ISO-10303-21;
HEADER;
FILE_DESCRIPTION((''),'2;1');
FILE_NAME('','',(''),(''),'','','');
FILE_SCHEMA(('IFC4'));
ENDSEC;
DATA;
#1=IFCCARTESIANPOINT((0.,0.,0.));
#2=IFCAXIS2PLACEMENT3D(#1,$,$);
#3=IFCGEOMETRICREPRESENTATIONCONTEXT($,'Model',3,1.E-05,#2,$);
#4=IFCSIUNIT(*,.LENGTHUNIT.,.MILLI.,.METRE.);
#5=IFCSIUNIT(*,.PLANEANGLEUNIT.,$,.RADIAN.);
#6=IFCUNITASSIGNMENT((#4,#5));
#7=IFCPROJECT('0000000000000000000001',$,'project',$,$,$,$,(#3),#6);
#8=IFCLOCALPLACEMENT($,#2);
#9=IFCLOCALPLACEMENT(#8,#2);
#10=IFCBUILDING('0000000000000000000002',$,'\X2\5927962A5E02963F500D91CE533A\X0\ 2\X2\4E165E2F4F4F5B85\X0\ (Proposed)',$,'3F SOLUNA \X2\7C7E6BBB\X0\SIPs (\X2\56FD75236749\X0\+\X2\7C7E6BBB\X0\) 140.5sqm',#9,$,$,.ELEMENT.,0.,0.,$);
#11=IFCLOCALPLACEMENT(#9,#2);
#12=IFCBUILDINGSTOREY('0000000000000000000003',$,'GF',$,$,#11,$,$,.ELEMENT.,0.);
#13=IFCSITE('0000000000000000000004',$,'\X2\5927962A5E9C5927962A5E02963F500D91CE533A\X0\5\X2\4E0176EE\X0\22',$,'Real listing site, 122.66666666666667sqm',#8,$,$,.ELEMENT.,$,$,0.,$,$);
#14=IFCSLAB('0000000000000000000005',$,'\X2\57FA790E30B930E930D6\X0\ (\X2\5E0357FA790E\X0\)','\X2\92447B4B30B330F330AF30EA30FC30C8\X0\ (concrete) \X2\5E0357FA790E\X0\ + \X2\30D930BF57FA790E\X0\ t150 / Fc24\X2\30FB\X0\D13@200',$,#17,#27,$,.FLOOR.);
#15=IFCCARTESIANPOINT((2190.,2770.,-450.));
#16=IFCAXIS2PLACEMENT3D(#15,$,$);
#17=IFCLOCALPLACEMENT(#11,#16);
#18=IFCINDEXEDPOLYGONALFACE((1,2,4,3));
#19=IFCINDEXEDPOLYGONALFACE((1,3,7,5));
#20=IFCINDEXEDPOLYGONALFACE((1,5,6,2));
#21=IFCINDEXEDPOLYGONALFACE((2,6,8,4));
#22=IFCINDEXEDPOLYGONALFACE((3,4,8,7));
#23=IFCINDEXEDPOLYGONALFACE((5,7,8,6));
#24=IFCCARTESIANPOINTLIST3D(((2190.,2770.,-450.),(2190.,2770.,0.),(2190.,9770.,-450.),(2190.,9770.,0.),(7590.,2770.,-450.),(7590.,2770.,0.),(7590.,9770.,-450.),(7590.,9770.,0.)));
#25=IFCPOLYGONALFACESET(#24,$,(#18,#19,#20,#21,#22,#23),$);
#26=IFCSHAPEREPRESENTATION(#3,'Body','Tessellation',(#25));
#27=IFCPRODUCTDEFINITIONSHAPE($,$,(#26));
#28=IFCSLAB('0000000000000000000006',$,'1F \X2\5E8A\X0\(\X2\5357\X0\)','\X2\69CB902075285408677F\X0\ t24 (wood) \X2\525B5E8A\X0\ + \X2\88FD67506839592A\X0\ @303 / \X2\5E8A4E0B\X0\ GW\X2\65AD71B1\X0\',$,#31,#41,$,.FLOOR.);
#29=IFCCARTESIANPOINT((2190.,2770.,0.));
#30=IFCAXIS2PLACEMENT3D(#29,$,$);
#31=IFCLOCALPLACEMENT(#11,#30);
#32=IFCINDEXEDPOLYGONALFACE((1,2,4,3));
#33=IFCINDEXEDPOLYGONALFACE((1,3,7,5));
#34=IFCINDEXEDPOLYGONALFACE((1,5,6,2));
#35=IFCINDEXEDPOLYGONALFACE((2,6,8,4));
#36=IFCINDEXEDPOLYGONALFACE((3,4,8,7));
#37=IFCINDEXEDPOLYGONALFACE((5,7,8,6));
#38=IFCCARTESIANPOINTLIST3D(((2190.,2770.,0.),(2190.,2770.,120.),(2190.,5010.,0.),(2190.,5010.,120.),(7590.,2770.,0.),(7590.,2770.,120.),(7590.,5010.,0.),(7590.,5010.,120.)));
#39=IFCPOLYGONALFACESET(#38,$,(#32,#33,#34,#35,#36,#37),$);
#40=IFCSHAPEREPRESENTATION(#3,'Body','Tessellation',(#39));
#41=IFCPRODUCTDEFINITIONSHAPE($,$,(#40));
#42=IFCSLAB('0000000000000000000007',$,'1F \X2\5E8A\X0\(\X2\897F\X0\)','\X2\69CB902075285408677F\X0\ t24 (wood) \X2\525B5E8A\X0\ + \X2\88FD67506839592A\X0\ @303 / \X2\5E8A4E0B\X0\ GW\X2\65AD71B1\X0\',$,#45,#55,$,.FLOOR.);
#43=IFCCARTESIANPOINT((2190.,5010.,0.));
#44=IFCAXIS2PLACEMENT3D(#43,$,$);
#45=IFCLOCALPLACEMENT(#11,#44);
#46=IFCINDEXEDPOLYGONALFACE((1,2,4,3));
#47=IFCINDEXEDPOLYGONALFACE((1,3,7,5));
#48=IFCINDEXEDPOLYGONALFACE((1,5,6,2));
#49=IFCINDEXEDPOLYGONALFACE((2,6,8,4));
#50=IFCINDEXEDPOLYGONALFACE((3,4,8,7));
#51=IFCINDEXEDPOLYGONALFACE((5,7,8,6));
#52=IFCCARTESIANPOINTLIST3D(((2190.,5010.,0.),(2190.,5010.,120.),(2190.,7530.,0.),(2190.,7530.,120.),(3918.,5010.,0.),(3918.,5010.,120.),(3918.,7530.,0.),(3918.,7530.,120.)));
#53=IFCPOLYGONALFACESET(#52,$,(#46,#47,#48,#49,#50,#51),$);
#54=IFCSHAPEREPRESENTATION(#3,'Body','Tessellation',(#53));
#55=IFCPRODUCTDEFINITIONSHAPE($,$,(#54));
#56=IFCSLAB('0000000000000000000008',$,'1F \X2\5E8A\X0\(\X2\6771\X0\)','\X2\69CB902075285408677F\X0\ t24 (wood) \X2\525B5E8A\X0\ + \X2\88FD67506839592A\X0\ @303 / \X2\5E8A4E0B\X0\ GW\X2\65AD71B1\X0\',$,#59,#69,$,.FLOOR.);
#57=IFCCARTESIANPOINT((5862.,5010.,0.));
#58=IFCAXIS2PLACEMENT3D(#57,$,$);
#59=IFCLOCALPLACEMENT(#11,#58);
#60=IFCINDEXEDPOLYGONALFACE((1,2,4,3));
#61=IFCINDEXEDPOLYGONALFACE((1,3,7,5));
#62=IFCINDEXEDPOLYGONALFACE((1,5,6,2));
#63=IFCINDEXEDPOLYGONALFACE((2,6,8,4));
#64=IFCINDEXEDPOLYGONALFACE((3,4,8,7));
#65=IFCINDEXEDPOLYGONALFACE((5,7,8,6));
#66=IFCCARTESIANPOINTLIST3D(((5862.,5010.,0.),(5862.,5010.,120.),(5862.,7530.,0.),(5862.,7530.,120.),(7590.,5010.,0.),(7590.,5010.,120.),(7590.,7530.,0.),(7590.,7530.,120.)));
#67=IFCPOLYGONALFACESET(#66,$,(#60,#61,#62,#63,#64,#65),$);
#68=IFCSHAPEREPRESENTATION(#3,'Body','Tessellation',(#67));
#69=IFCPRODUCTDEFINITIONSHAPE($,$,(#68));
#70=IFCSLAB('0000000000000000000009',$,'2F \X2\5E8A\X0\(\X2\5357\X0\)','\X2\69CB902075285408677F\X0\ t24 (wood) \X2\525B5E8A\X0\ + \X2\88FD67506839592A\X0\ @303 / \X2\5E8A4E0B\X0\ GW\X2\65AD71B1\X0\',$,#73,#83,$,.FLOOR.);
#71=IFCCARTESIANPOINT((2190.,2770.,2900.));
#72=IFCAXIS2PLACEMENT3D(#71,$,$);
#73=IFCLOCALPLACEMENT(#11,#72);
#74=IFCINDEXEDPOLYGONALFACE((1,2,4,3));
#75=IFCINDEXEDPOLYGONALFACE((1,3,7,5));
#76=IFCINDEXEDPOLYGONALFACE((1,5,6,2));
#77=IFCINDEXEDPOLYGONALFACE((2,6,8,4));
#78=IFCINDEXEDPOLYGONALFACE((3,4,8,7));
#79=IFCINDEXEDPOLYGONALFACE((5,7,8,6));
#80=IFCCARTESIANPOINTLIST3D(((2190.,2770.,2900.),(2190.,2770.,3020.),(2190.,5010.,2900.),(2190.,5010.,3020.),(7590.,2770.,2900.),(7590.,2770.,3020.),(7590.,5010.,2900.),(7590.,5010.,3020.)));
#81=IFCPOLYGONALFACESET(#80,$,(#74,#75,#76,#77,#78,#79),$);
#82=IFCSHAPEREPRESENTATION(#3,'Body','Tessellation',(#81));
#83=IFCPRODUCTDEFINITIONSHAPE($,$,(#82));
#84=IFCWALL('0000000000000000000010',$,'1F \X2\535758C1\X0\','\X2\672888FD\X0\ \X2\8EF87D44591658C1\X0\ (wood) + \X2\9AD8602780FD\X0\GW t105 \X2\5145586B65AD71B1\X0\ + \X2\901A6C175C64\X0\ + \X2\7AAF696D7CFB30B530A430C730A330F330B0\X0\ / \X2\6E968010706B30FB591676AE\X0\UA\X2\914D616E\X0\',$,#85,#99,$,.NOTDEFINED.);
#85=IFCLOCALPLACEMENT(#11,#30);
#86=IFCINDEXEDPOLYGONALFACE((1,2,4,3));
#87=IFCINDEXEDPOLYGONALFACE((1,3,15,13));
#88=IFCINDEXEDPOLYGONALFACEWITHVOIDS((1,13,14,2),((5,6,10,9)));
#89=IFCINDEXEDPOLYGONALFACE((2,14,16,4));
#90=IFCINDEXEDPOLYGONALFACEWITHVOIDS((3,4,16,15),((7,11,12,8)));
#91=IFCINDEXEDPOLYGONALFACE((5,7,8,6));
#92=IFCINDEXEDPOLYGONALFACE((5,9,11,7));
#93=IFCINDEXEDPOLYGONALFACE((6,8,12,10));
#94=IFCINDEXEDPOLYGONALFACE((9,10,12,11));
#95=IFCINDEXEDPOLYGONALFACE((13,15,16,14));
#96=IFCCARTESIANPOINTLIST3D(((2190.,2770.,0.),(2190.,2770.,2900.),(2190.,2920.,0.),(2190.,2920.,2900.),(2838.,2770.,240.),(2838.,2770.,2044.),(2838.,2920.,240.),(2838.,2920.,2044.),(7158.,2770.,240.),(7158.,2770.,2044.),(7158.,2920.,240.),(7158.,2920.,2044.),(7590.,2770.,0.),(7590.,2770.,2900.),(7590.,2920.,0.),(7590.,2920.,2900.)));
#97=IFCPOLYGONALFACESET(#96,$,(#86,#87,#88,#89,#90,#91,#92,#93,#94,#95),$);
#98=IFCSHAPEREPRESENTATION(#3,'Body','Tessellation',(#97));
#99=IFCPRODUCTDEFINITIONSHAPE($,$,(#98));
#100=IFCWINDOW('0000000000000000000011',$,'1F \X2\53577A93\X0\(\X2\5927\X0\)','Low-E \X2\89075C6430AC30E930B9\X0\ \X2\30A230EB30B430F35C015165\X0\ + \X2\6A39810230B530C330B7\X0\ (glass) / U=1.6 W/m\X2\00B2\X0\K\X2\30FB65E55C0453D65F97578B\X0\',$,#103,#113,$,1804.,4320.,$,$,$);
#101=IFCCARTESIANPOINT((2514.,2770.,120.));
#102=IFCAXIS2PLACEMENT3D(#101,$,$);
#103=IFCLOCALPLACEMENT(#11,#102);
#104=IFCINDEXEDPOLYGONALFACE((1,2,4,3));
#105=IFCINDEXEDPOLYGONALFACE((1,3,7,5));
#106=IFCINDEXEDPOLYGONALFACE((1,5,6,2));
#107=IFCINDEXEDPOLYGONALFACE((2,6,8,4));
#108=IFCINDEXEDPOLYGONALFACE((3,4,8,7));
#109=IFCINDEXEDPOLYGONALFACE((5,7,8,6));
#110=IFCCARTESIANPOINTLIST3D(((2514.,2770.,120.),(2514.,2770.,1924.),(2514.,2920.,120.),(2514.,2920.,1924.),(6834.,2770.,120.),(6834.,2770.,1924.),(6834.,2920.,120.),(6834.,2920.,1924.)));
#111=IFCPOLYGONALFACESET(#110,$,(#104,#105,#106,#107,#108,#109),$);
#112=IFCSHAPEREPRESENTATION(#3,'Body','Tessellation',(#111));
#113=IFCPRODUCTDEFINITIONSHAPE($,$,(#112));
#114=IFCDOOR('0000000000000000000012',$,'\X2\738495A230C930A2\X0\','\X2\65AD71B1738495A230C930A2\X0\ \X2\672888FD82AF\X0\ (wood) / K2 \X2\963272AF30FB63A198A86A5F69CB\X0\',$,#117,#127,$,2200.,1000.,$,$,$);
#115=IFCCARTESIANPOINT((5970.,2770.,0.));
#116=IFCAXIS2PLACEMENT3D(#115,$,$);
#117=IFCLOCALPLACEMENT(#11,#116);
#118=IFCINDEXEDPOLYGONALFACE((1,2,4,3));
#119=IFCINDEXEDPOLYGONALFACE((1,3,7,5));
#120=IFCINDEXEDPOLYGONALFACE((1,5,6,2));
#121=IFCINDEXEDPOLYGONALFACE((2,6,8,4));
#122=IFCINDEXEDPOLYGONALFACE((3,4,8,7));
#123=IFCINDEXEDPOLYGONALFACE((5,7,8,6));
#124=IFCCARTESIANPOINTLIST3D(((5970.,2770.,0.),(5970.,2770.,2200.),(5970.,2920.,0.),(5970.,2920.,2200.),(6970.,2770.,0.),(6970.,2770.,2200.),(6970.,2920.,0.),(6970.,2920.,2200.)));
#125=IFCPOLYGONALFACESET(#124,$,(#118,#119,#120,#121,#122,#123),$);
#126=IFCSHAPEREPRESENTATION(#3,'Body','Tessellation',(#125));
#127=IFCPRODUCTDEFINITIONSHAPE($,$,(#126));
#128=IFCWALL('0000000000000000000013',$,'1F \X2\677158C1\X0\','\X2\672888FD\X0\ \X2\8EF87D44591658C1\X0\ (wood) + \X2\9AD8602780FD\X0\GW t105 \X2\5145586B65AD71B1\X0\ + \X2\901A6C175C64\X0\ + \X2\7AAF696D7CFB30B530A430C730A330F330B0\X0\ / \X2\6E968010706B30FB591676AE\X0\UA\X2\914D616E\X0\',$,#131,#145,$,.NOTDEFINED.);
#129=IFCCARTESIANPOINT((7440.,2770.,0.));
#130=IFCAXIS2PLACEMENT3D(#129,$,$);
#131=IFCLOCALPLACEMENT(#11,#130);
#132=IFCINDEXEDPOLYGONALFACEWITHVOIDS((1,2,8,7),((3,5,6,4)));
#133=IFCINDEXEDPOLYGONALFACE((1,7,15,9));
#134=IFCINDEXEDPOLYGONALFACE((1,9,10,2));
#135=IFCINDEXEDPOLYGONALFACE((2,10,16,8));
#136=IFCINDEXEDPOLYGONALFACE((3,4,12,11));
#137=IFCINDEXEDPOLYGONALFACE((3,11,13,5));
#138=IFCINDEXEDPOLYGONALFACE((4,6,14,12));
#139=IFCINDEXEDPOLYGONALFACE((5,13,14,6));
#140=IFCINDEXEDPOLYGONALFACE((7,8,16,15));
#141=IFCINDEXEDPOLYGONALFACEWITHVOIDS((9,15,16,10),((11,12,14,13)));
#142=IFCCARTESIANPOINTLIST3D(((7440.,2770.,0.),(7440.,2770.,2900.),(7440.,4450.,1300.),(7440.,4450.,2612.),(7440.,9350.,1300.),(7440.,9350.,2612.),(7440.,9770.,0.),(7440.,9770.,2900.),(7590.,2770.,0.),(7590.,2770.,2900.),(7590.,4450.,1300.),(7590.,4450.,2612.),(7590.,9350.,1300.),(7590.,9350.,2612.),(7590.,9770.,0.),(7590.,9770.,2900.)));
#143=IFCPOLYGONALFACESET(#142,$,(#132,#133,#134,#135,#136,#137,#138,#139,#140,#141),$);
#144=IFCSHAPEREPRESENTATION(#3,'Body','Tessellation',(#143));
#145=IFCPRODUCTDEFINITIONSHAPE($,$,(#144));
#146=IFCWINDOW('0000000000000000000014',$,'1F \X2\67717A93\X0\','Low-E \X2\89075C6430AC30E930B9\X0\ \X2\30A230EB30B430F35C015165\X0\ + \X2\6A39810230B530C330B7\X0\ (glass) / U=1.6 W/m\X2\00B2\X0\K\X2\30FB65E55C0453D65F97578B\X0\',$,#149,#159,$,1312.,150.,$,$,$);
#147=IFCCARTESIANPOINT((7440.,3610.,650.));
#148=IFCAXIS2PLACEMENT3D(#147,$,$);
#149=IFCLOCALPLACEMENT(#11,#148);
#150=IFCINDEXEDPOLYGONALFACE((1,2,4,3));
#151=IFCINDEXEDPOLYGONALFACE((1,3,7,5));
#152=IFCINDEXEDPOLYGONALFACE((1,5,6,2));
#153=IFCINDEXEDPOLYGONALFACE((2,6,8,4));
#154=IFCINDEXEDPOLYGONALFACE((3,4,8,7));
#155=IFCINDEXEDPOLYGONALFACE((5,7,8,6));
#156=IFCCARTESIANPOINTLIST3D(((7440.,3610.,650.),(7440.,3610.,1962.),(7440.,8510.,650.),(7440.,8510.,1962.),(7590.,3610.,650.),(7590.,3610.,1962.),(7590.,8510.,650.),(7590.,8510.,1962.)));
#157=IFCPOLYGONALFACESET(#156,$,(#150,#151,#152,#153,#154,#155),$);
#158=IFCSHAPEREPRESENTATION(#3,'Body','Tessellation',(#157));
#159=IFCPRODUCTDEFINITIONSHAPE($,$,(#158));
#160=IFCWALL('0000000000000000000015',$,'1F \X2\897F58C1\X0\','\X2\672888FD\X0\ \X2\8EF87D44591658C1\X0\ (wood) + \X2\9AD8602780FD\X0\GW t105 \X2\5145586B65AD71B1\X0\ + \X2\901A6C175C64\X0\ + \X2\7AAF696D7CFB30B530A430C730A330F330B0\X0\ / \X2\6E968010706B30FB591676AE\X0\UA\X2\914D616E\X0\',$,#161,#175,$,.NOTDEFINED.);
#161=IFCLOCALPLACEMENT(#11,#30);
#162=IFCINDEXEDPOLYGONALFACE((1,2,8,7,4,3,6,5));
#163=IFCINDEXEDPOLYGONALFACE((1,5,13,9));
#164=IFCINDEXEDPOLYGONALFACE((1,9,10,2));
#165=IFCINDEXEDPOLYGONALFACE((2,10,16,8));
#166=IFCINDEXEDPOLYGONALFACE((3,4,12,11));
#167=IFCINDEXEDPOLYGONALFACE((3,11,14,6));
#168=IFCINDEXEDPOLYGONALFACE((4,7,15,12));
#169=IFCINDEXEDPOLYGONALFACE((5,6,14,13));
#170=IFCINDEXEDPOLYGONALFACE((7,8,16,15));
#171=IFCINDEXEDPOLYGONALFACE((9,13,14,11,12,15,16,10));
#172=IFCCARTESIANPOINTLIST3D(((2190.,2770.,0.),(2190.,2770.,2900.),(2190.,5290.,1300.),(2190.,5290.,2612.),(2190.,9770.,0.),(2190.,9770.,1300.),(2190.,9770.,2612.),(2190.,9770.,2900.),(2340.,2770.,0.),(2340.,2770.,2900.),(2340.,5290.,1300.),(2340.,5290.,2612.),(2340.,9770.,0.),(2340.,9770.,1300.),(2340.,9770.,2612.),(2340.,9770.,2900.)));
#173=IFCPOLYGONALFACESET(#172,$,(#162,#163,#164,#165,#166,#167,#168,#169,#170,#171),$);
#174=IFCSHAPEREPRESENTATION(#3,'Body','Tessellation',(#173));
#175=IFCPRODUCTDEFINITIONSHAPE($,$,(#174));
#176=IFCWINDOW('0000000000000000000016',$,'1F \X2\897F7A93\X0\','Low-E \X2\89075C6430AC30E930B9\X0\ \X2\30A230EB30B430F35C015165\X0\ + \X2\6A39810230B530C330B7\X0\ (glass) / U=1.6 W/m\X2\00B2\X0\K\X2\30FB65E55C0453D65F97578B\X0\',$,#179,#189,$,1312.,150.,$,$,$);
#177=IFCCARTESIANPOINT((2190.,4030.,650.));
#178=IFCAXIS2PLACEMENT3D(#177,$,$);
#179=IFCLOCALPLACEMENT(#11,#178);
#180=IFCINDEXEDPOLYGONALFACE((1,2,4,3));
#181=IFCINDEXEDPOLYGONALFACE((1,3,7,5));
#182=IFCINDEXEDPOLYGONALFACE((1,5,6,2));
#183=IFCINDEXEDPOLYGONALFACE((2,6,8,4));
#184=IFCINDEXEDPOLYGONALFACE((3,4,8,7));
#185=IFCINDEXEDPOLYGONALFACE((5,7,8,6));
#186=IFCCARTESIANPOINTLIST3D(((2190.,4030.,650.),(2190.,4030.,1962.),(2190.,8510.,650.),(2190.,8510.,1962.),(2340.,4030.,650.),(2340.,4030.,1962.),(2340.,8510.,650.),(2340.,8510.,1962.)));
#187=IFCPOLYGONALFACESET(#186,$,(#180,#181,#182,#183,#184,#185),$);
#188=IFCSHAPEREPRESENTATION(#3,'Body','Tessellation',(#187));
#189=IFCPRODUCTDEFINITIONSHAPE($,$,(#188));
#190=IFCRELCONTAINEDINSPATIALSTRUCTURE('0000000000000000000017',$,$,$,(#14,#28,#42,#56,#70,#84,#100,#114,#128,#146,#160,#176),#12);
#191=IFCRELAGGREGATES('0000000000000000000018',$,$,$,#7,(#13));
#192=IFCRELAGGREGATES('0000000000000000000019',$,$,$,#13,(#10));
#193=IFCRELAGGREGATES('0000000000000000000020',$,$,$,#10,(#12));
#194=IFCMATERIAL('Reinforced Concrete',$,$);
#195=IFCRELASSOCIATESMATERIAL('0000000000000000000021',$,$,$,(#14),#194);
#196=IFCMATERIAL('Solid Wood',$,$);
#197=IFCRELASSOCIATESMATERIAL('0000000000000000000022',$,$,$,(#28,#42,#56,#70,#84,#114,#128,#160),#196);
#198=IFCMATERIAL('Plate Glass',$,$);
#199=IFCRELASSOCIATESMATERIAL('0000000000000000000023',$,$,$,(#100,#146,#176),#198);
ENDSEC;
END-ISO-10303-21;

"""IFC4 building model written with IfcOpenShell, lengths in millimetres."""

from ifc_helpers import new_model, si_unit, frame, frame_2d, origin, place, context, project, spatial, rectangle, extrude, material, element, fill, save


model = new_model("IFC4")

# Units and contexts
model_context = context("Model", 3, precision=1e-05, world=origin())
ifc_project = project(units=[si_unit("LENGTHUNIT", "METRE", prefix="MILLI"), si_unit("PLANEANGLEUNIT", "RADIAN")], contexts=[model_context])

# Site, building, storey
site_placement = place(None, origin())
site = spatial("IfcSite", under=ifc_project, at=site_placement, Name="大阪府大阪市阿倍野区5丁目22", ObjectType="Real listing site, 122.66666666666667sqm", CompositionType="ELEMENT", RefElevation=0.0)
building_placement = place(site_placement, origin())
building = spatial("IfcBuilding", under=site, at=building_placement, Name="大阪市阿倍野区 2世帯住宅 (Proposed)", ObjectType="3F SOLUNA 籾殻SIPs (国産杉+籾殻) 140.5sqm", CompositionType="ELEMENT", ElevationOfRefHeight=0.0, ElevationOfTerrain=0.0)
storey_placement = place(building_placement, origin())
storey = spatial("IfcBuildingStorey", under=building, at=storey_placement, Name="GF", CompositionType="ELEMENT", Elevation=0.0)

# Slabs
ifc_material_1 = material(Name="Reinforced Concrete")
slab_1_placement = place(storey_placement, frame((2190.0, 2770.0, -450.0)))
element("IfcSlab", 1, at=slab_1_placement, inside=storey, material=ifc_material_1, Name="基礎スラブ (布基礎)", Description="鉄筋コンクリート (concrete) 布基礎 + ベタ基礎 t150 / Fc24・D13@200", PredefinedType="FLOOR", context=model_context, shape_type="SweptSolid", body=[
    extrude(rectangle(XDim=5400.0, YDim=7000.0, at=frame_2d((2700.0, 3500.0))), frame((2190.0, 2770.0, -450.0)), (0.0, 0.0, 1.0), 450.0),
])
ifc_material_2 = material(Name="Solid Wood")
slab_2_placement = place(storey_placement, frame((2190.0, 2770.0, 0.0)))
element("IfcSlab", 2, at=slab_2_placement, inside=storey, material=ifc_material_2, Name="1F 床(南)", Description="構造用合板 t24 (wood) 剛床 + 製材根太 @303 / 床下 GW断熱", PredefinedType="FLOOR", context=model_context, shape_type="SweptSolid", body=[
    extrude(rectangle(XDim=5400.0, YDim=2240.0, at=frame_2d((2700.0, 1120.0))), frame((2190.0, 2770.0, 0.0)), (0.0, 0.0, 1.0), 120.0),
])
slab_3_placement = place(storey_placement, frame((2190.0, 5010.0, 0.0)))
element("IfcSlab", 3, at=slab_3_placement, inside=storey, material=ifc_material_2, Name="1F 床(西)", Description="構造用合板 t24 (wood) 剛床 + 製材根太 @303 / 床下 GW断熱", PredefinedType="FLOOR", context=model_context, shape_type="SweptSolid", body=[
    extrude(rectangle(XDim=1728.0, YDim=2520.0, at=frame_2d((864.0, 1260.0))), frame((2190.0, 5010.0, 0.0)), (0.0, 0.0, 1.0), 120.0),
])
slab_4_placement = place(storey_placement, frame((5862.0, 5010.0, 0.0)))
element("IfcSlab", 4, at=slab_4_placement, inside=storey, material=ifc_material_2, Name="1F 床(東)", Description="構造用合板 t24 (wood) 剛床 + 製材根太 @303 / 床下 GW断熱", PredefinedType="FLOOR", context=model_context, shape_type="SweptSolid", body=[
    extrude(rectangle(XDim=1728.0, YDim=2520.0, at=frame_2d((864.0, 1260.0))), frame((5862.0, 5010.0, 0.0)), (0.0, 0.0, 1.0), 120.0),
])
slab_5_placement = place(storey_placement, frame((2190.0, 2770.0, 2900.0)))
element("IfcSlab", 5, at=slab_5_placement, inside=storey, material=ifc_material_2, Name="2F 床(南)", Description="構造用合板 t24 (wood) 剛床 + 製材根太 @303 / 床下 GW断熱", PredefinedType="FLOOR", context=model_context, shape_type="SweptSolid", body=[
    extrude(rectangle(XDim=5400.0, YDim=2240.0, at=frame_2d((2700.0, 1120.0))), frame((2190.0, 2770.0, 2900.0)), (0.0, 0.0, 1.0), 120.0),
])

# Wall, openings, window, door
wall_1_placement = place(storey_placement, frame((2190.0, 2770.0, 0.0)))
wall_1 = element("IfcWall", 6, at=wall_1_placement, inside=storey, material=ifc_material_2, Name="1F 南壁", Description="木製 軸組外壁 (wood) + 高性能GW t105 充填断熱 + 通気層 + 窯業系サイディング / 準耐火・外皮UA配慮", PredefinedType="NOTDEFINED", context=model_context, shape_type="SweptSolid", body=[
    extrude(rectangle(XDim=5400.0, YDim=150.0, at=frame_2d((2700.0, 75.0))), frame((2190.0, 2770.0, 0.0)), (0.0, 0.0, 1.0), 2900.0),
])
opening_1_placement = place(storey_placement, frame((2514.0, 2770.0, 120.0)))
opening_1 = element("IfcOpeningElement", 7, at=opening_1_placement, cuts=wall_1, PredefinedType="NOTDEFINED", context=model_context, shape_type="SweptSolid", body=[
    extrude(rectangle(XDim=4320.0, YDim=150.0, at=frame_2d((2160.0, 75.0))), frame((2514.0, 2770.0, 120.0)), (0.0, 0.0, 1.0), 1804.0),
])
opening_2_placement = place(storey_placement, frame((5970.0, 2770.0, 0.0)))
opening_2 = element("IfcOpeningElement", 8, at=opening_2_placement, cuts=wall_1, PredefinedType="NOTDEFINED", context=model_context, shape_type="SweptSolid", body=[
    extrude(rectangle(XDim=1000.0, YDim=150.0, at=frame_2d((500.0, 75.0))), frame((5970.0, 2770.0, 0.0)), (0.0, 0.0, 1.0), 2200.0),
])
ifc_material_3 = material(Name="Plate Glass")
window_1_placement = place(storey_placement, frame((2514.0, 2770.0, 120.0)))
window_1 = element("IfcWindow", 9, at=window_1_placement, inside=storey, material=ifc_material_3, Name="1F 南窓(大)", Description="Low-E 複層ガラス アルゴン封入 + 樹脂サッシ (glass) / U=1.6 W/m²K・日射取得型", OverallHeight=1804.0, OverallWidth=4320.0, context=model_context, shape_type="SweptSolid", body=[
    extrude(rectangle(XDim=4320.0, YDim=150.0, at=frame_2d((2160.0, 75.0))), frame((2514.0, 2770.0, 120.0)), (0.0, 0.0, 1.0), 1804.0),
])
fill(opening_1, window_1)
door_placement = place(storey_placement, frame((5970.0, 2770.0, 0.0)))
door = element("IfcDoor", 10, at=door_placement, inside=storey, material=ifc_material_2, Name="玄関ドア", Description="断熱玄関ドア 木製芯 (wood) / K2 防犯・採風機構", OverallHeight=2200.0, OverallWidth=1000.0, context=model_context, shape_type="SweptSolid", body=[
    extrude(rectangle(XDim=1000.0, YDim=150.0, at=frame_2d((500.0, 75.0))), frame((5970.0, 2770.0, 0.0)), (0.0, 0.0, 1.0), 2200.0),
])
fill(opening_2, door)

# Walls, openings, windows
wall_2_placement = place(storey_placement, frame((7440.0, 2770.0, 0.0)))
wall_2 = element("IfcWall", 11, at=wall_2_placement, inside=storey, material=ifc_material_2, Name="1F 東壁", Description="木製 軸組外壁 (wood) + 高性能GW t105 充填断熱 + 通気層 + 窯業系サイディング / 準耐火・外皮UA配慮", PredefinedType="NOTDEFINED", context=model_context, shape_type="SweptSolid", body=[
    extrude(rectangle(XDim=150.0, YDim=7000.0, at=frame_2d((75.0, 3500.0))), frame((7440.0, 2770.0, 0.0)), (0.0, 0.0, 1.0), 2900.0),
])
opening_3_placement = place(storey_placement, frame((7440.0, 3610.0, 650.0)))
opening_3 = element("IfcOpeningElement", 12, at=opening_3_placement, cuts=wall_2, PredefinedType="NOTDEFINED", context=model_context, shape_type="SweptSolid", body=[
    extrude(rectangle(XDim=150.0, YDim=4900.0, at=frame_2d((75.0, 2450.0))), frame((7440.0, 3610.0, 650.0)), (0.0, 0.0, 1.0), 1312.0),
])
window_2_placement = place(storey_placement, frame((7440.0, 3610.0, 650.0)))
window_2 = element("IfcWindow", 13, at=window_2_placement, inside=storey, material=ifc_material_3, Name="1F 東窓", Description="Low-E 複層ガラス アルゴン封入 + 樹脂サッシ (glass) / U=1.6 W/m²K・日射取得型", OverallHeight=1312.0, OverallWidth=150.0, context=model_context, shape_type="SweptSolid", body=[
    extrude(rectangle(XDim=150.0, YDim=4900.0, at=frame_2d((75.0, 2450.0))), frame((7440.0, 3610.0, 650.0)), (0.0, 0.0, 1.0), 1312.0),
])
fill(opening_3, window_2)
wall_3_placement = place(storey_placement, frame((2190.0, 2770.0, 0.0)))
wall_3 = element("IfcWall", 14, at=wall_3_placement, inside=storey, material=ifc_material_2, Name="1F 西壁", Description="木製 軸組外壁 (wood) + 高性能GW t105 充填断熱 + 通気層 + 窯業系サイディング / 準耐火・外皮UA配慮", PredefinedType="NOTDEFINED", context=model_context, shape_type="SweptSolid", body=[
    extrude(rectangle(XDim=150.0, YDim=7000.0, at=frame_2d((75.0, 3500.0))), frame((2190.0, 2770.0, 0.0)), (0.0, 0.0, 1.0), 2900.0),
])
opening_4_placement = place(storey_placement, frame((2190.0, 4030.0, 650.0)))
opening_4 = element("IfcOpeningElement", 15, at=opening_4_placement, cuts=wall_3, PredefinedType="NOTDEFINED", context=model_context, shape_type="SweptSolid", body=[
    extrude(rectangle(XDim=150.0, YDim=4480.0, at=frame_2d((75.0, 2240.0))), frame((2190.0, 4030.0, 650.0)), (0.0, 0.0, 1.0), 1312.0),
])
window_3_placement = place(storey_placement, frame((2190.0, 4030.0, 650.0)))
window_3 = element("IfcWindow", 16, at=window_3_placement, inside=storey, material=ifc_material_3, Name="1F 西窓", Description="Low-E 複層ガラス アルゴン封入 + 樹脂サッシ (glass) / U=1.6 W/m²K・日射取得型", OverallHeight=1312.0, OverallWidth=150.0, context=model_context, shape_type="SweptSolid", body=[
    extrude(rectangle(XDim=150.0, YDim=4480.0, at=frame_2d((75.0, 2240.0))), frame((2190.0, 4030.0, 650.0)), (0.0, 0.0, 1.0), 1312.0),
])
fill(opening_4, window_3)

save(model, "model.ifc")
